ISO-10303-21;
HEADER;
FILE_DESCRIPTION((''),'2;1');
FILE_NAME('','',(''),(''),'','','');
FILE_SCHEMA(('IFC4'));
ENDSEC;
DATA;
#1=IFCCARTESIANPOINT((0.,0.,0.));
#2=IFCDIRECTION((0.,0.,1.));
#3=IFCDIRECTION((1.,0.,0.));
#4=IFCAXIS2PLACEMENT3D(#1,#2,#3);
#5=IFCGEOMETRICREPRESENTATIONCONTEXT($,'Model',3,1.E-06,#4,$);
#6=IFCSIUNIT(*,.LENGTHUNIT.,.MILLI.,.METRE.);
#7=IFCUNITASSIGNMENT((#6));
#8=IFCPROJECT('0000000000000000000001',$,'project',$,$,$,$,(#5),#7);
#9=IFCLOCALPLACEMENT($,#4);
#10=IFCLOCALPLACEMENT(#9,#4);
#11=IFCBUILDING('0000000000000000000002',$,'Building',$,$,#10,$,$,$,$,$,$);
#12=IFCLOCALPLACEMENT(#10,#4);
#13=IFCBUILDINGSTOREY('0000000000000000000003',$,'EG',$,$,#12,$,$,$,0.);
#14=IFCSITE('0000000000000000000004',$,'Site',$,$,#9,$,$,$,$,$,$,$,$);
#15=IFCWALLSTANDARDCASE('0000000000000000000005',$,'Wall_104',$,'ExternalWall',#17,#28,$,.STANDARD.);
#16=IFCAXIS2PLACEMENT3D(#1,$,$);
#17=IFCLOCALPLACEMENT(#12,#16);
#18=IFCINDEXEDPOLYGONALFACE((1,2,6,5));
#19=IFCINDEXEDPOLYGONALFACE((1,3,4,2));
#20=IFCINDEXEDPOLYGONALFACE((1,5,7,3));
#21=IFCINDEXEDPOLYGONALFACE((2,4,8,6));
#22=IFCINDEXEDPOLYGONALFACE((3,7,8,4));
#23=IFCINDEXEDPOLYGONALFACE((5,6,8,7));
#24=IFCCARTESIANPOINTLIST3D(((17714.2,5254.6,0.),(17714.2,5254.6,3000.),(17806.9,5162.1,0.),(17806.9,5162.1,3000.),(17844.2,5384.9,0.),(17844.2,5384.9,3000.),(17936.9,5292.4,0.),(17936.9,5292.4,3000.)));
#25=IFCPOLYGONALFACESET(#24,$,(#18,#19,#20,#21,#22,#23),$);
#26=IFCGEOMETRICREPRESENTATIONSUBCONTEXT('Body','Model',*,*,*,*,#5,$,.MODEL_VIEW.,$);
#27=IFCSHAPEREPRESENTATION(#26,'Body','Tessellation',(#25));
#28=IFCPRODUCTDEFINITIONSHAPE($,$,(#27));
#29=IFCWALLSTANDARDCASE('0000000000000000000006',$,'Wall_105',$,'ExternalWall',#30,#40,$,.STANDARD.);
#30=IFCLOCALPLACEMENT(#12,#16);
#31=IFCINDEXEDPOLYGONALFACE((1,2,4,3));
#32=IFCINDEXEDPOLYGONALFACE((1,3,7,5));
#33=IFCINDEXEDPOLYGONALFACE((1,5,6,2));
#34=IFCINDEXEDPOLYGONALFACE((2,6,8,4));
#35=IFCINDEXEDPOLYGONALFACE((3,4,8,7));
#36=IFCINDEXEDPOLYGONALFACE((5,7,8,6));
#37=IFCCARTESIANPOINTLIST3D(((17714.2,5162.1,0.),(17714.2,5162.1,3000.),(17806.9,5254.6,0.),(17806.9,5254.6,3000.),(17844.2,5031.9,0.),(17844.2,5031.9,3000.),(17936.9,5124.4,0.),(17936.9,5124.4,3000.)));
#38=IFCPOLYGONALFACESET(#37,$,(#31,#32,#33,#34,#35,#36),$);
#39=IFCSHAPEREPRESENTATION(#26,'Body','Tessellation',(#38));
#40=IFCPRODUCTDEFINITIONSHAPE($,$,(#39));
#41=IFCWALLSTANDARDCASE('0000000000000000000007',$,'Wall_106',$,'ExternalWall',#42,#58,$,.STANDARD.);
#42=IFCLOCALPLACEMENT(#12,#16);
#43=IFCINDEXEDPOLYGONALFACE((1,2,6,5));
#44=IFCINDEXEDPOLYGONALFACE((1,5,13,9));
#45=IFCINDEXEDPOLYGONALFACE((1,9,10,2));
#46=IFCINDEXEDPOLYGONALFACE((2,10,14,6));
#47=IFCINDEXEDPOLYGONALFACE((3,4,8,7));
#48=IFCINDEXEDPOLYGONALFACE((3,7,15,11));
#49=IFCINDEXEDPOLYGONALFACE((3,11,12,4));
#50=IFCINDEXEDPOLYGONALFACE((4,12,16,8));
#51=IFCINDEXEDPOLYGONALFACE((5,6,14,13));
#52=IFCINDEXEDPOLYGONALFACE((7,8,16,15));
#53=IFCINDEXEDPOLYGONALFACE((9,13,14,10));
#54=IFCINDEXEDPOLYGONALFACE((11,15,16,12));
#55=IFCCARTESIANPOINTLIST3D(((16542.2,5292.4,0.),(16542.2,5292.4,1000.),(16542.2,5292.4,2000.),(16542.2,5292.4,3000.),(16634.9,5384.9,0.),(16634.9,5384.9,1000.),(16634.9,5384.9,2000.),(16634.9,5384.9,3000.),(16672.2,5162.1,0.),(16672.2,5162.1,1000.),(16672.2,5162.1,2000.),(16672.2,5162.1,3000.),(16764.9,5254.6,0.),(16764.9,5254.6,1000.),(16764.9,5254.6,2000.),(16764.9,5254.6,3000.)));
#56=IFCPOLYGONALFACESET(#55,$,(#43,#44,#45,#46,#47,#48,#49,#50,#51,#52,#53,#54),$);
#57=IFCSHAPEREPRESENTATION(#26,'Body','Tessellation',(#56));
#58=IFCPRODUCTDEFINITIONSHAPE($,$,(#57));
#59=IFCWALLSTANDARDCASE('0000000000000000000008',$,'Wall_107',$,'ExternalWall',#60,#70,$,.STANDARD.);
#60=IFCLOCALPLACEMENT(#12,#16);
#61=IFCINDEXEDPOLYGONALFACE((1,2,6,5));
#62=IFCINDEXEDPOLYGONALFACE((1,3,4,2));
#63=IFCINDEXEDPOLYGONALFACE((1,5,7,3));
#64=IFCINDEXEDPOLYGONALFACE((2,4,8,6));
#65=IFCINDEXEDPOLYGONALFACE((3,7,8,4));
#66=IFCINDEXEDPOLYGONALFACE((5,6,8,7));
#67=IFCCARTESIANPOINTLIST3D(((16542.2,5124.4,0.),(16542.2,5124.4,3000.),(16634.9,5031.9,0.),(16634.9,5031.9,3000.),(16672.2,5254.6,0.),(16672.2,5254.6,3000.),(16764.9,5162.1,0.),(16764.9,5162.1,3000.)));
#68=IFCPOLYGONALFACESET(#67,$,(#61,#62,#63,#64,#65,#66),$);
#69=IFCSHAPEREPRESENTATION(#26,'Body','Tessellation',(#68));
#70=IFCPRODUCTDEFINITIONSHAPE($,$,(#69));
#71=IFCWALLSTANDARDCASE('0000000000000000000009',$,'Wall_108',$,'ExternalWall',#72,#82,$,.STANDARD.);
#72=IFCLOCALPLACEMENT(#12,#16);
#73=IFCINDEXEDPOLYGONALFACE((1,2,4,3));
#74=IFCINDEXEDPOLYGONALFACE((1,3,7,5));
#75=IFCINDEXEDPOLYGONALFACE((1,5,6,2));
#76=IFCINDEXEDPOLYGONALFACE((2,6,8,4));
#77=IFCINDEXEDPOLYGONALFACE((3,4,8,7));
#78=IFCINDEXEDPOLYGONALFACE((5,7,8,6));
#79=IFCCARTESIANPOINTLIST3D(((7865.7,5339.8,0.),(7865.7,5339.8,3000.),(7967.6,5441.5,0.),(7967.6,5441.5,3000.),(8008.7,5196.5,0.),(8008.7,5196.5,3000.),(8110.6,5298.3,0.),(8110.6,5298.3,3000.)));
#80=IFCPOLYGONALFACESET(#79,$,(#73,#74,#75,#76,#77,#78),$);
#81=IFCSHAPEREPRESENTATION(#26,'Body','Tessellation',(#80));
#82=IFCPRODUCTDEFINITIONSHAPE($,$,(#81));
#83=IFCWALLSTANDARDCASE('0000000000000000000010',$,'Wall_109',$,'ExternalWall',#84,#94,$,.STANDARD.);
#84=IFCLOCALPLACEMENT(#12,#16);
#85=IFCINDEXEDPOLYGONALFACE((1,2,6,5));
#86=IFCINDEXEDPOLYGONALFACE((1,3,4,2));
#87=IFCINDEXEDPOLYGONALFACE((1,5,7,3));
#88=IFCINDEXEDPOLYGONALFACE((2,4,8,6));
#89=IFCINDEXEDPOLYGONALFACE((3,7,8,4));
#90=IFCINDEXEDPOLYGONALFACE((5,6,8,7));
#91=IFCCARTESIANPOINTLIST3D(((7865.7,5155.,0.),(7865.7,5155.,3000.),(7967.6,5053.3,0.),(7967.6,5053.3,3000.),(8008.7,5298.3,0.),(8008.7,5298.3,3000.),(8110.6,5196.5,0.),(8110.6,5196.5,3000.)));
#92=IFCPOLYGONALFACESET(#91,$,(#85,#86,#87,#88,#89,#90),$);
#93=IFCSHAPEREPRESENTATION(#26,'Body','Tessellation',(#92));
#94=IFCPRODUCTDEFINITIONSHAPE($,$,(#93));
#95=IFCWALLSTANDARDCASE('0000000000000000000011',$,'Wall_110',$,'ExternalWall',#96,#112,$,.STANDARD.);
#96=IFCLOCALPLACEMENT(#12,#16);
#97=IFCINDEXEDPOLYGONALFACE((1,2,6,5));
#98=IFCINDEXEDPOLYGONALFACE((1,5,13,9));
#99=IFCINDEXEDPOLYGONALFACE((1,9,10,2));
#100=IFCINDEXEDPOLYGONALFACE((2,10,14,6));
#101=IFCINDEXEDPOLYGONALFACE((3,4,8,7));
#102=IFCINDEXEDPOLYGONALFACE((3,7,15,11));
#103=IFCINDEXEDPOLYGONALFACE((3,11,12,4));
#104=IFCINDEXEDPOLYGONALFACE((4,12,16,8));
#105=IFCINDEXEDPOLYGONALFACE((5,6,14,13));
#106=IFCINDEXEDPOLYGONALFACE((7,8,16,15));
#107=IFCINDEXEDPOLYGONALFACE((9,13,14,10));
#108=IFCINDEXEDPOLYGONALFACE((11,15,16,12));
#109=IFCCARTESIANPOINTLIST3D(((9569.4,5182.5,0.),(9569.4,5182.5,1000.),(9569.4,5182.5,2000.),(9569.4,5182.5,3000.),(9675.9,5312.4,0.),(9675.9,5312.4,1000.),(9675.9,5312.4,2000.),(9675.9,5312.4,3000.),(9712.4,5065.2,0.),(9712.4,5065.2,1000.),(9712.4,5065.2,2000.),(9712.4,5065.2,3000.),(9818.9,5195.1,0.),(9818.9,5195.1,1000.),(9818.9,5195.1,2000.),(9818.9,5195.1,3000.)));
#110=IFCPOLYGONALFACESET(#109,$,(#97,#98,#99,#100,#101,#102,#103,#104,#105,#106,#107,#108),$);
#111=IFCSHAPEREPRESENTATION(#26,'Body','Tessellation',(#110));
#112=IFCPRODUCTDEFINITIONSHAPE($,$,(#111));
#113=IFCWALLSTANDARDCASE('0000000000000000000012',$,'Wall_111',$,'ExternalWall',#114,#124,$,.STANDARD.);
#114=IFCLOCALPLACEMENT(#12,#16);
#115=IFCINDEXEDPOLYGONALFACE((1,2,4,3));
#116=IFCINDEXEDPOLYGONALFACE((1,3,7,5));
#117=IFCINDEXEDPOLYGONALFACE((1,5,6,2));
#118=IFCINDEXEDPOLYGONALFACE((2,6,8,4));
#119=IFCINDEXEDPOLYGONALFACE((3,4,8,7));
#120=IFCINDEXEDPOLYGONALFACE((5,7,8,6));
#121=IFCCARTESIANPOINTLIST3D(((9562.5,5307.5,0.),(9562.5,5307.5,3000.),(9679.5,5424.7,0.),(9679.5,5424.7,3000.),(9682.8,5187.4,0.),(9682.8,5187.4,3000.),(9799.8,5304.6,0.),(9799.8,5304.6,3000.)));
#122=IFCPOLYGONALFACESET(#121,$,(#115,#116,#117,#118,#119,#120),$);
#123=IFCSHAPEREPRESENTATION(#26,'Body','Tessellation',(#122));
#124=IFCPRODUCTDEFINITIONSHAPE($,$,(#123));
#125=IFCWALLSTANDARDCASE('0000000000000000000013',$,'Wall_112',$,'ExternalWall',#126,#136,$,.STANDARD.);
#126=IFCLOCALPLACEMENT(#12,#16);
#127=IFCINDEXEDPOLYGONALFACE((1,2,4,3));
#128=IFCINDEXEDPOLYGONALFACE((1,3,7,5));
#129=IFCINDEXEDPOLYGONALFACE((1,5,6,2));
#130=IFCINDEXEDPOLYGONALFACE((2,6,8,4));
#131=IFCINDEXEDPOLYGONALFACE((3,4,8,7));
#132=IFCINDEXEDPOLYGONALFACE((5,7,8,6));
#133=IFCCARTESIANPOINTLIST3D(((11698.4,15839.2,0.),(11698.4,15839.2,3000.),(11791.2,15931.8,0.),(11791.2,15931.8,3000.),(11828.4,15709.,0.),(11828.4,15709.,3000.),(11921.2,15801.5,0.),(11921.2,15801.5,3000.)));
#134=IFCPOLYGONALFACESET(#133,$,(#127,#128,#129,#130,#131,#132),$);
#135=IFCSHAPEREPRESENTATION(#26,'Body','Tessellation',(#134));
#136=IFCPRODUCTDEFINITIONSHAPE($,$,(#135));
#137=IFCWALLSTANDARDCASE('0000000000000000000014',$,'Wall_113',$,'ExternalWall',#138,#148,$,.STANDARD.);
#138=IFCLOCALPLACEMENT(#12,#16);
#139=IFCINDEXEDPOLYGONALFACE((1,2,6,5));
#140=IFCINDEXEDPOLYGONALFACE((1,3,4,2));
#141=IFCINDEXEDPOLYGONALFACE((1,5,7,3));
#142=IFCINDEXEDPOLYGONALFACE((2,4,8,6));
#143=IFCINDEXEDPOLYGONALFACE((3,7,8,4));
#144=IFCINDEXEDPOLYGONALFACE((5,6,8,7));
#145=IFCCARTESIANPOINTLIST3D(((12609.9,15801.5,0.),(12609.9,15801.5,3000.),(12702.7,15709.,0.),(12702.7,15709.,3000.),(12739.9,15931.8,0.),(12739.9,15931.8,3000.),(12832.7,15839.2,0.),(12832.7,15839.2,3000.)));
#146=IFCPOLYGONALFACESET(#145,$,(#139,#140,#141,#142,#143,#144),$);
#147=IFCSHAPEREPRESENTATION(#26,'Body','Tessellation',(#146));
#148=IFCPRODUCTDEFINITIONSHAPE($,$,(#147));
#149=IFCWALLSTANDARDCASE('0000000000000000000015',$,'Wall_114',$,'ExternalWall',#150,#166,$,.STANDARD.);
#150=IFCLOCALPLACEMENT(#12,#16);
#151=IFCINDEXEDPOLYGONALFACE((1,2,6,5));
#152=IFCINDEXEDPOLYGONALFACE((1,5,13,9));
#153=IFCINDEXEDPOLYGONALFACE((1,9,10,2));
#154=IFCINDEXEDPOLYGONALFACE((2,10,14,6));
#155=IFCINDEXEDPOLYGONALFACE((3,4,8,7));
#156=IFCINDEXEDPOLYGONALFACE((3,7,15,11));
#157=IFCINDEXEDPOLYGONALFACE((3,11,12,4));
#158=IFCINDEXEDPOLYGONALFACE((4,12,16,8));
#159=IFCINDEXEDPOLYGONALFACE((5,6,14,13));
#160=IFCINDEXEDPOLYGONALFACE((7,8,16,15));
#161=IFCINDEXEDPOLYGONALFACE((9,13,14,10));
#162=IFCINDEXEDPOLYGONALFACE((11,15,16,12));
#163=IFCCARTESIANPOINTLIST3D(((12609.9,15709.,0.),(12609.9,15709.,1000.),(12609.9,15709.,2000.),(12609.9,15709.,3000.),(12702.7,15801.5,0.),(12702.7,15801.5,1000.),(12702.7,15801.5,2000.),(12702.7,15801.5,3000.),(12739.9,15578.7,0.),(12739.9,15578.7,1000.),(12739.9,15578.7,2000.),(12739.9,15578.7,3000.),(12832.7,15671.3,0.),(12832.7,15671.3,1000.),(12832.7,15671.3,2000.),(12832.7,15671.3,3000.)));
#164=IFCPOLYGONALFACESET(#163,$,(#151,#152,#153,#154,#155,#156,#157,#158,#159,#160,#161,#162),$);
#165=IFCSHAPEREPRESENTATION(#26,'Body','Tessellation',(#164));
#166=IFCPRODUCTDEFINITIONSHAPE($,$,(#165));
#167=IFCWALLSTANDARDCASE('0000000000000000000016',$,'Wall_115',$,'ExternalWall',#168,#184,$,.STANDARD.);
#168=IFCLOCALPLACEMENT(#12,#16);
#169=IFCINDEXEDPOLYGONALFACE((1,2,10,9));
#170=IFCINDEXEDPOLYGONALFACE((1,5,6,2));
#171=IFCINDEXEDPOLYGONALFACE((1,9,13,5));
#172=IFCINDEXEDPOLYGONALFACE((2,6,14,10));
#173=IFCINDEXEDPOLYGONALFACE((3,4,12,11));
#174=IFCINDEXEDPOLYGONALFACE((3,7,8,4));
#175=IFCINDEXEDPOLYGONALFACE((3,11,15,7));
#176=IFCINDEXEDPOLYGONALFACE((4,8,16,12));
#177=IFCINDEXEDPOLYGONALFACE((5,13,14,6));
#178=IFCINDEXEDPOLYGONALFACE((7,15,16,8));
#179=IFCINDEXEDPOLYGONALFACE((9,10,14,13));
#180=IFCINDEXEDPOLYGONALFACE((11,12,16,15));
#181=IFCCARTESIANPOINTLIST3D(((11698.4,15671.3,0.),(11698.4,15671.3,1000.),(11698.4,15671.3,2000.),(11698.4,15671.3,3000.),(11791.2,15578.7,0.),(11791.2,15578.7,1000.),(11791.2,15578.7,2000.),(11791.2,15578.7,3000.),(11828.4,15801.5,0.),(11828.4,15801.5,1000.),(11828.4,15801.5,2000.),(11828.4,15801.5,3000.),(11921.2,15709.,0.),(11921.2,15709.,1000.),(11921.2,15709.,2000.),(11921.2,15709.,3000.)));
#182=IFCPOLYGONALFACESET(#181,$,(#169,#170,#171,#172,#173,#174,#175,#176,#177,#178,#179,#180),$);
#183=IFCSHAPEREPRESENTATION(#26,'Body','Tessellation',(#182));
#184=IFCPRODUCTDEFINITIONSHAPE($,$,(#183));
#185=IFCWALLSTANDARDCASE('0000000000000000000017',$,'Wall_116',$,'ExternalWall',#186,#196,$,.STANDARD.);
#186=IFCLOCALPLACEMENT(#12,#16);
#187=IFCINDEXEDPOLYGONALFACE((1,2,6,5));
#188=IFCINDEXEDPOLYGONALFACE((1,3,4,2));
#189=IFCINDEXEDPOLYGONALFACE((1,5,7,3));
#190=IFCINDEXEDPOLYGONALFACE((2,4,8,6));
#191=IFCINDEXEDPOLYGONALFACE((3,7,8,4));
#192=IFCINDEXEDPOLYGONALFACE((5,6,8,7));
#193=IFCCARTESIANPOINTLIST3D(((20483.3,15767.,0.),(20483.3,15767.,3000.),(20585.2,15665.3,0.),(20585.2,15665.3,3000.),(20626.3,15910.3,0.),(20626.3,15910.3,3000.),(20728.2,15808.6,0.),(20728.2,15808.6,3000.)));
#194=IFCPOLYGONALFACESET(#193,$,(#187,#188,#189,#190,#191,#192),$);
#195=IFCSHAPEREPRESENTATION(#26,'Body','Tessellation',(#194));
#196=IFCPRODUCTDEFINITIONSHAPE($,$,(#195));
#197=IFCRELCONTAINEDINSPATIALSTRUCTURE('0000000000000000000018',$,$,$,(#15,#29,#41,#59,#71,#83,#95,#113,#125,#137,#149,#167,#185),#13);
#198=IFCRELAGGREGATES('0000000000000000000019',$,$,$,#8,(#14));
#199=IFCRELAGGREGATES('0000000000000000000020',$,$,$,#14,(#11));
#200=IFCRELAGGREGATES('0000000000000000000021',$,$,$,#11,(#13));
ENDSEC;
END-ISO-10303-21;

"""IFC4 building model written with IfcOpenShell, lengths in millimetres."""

from ifc_helpers import new_model, si_unit, frame, origin_with_axes, place, context, subcontext, project, spatial, rectangle, extrude, element, save


model = new_model("IFC4")

# Units and contexts
model_context = context("Model", 3, precision=1e-06, world=origin_with_axes())
body_context = subcontext(model_context, "Body", "Model", "MODEL_VIEW")
ifc_project = project(units=[si_unit("LENGTHUNIT", "METRE", prefix="MILLI")], contexts=[model_context])

# Site, building, storey
site_placement = place(None, origin_with_axes())
site = spatial("IfcSite", under=ifc_project, at=site_placement, Name="Site")
building_placement = place(site_placement, origin_with_axes())
building = spatial("IfcBuilding", under=site, at=building_placement, Name="Building")
storey_placement = place(building_placement, origin_with_axes())
storey = spatial("IfcBuildingStorey", under=building, at=storey_placement, Name="EG", Elevation=0.0)

# Walls
wall_1_placement = place(storey_placement, origin_with_axes())
element("IfcWallStandardCase", 1, at=wall_1_placement, inside=storey, Name="Wall_104", ObjectType="ExternalWall", PredefinedType="STANDARD", context=body_context, shape_type="SweptSolid", body=[
    extrude(rectangle(XDim=184.0, YDim=131.0), frame((17825.5, 5273.5, 0.0), z_axis=(0.0, 0.0, 1.0), x_axis=(0.706427, 0.707786, 0.0)), (0.0, 0.0, 1.0), 3000.0),
])
wall_2_placement = place(storey_placement, origin_with_axes())
element("IfcWallStandardCase", 2, at=wall_2_placement, inside=storey, Name="Wall_105", ObjectType="ExternalWall", PredefinedType="STANDARD", context=body_context, shape_type="SweptSolid", body=[
    extrude(rectangle(XDim=184.0, YDim=131.0), frame((17825.5, 5143.3, 0.0), z_axis=(0.0, 0.0, 1.0), x_axis=(0.706427, -0.707786, 0.0)), (0.0, 0.0, 1.0), 3000.0),
])

# Wall, opening
wall_3_placement = place(storey_placement, origin_with_axes())
wall_3 = element("IfcWallStandardCase", 3, at=wall_3_placement, inside=storey, Name="Wall_106", ObjectType="ExternalWall", PredefinedType="STANDARD", context=body_context, shape_type="SweptSolid", body=[
    extrude(rectangle(XDim=184.0, YDim=131.0), frame((16653.5, 5273.5, 0.0), z_axis=(0.0, 0.0, 1.0), x_axis=(-0.706427, 0.707786, 0.0)), (0.0, 0.0, 1.0), 3000.0),
])
opening_1_placement = place(wall_3_placement, origin_with_axes())
element("IfcOpeningElement", 4, at=opening_1_placement, inside=storey, cuts=wall_3, context=body_context, shape_type="SweptSolid", body=[
    extrude(rectangle(XDim=600.0, YDim=131.0), frame((16647.2, 5279.9, 1000.0), z_axis=(0.0, 0.0, 1.0), x_axis=(-0.706427, 0.707786, 0.0)), (0.0, 0.0, 1.0), 1000.0),
])

# Walls
wall_4_placement = place(storey_placement, origin_with_axes())
element("IfcWallStandardCase", 5, at=wall_4_placement, inside=storey, Name="Wall_107", ObjectType="ExternalWall", PredefinedType="STANDARD", context=body_context, shape_type="SweptSolid", body=[
    extrude(rectangle(XDim=184.0, YDim=131.0), frame((16653.5, 5143.3, 0.0), z_axis=(0.0, 0.0, 1.0), x_axis=(-0.706427, -0.707786, 0.0)), (0.0, 0.0, 1.0), 3000.0),
])
wall_5_placement = place(storey_placement, origin_with_axes())
element("IfcWallStandardCase", 6, at=wall_5_placement, inside=storey, Name="Wall_108", ObjectType="ExternalWall", PredefinedType="STANDARD", context=body_context, shape_type="SweptSolid", body=[
    extrude(rectangle(XDim=202.4, YDim=144.0), frame((7988.2, 5319.0, 0.0), z_axis=(0.0, 0.0, 1.0), x_axis=(-0.706489, 0.707724, 0.0)), (0.0, 0.0, 1.0), 3000.0),
])
wall_6_placement = place(storey_placement, origin_with_axes())
element("IfcWallStandardCase", 7, at=wall_6_placement, inside=storey, Name="Wall_109", ObjectType="ExternalWall", PredefinedType="STANDARD", context=body_context, shape_type="SweptSolid", body=[
    extrude(rectangle(XDim=202.4, YDim=144.0), frame((7988.2, 5175.8, 0.0), z_axis=(0.0, 0.0, 1.0), x_axis=(-0.706489, -0.707724, 0.0)), (0.0, 0.0, 1.0), 3000.0),
])

# Wall, opening
wall_7_placement = place(storey_placement, origin_with_axes())
wall_7 = element("IfcWallStandardCase", 8, at=wall_7_placement, inside=storey, Name="Wall_110", ObjectType="ExternalWall", PredefinedType="STANDARD", context=body_context, shape_type="SweptSolid", body=[
    extrude(rectangle(XDim=184.9, YDim=168.0), frame((9694.2, 5188.8, 0.0), z_axis=(0.0, 0.0, 1.0), x_axis=(0.773294, -0.634047, 0.0)), (0.0, 0.0, 1.0), 3000.0),
])
opening_2_placement = place(wall_7_placement, origin_with_axes())
element("IfcOpeningElement", 9, at=opening_2_placement, inside=storey, cuts=wall_7, context=body_context, shape_type="SweptSolid", body=[
    extrude(rectangle(XDim=600.0, YDim=168.0), frame((9717.4, 5169.8, 1000.0), z_axis=(0.0, 0.0, 1.0), x_axis=(0.773294, -0.634047, 0.0)), (0.0, 0.0, 1.0), 1000.0),
])

# Walls
wall_8_placement = place(storey_placement, origin_with_axes())
element("IfcWallStandardCase", 10, at=wall_8_placement, inside=storey, Name="Wall_111", ObjectType="ExternalWall", PredefinedType="STANDARD", context=body_context, shape_type="SweptSolid", body=[
    extrude(rectangle(XDim=165.6, YDim=170.0), frame((9681.2, 5306.0, 0.0), z_axis=(0.0, 0.0, 1.0), x_axis=(0.706352, 0.707861, 0.0)), (0.0, 0.0, 1.0), 3000.0),
])
wall_9_placement = place(storey_placement, origin_with_axes())
element("IfcWallStandardCase", 11, at=wall_9_placement, inside=storey, Name="Wall_112", ObjectType="ExternalWall", PredefinedType="STANDARD", context=body_context, shape_type="SweptSolid", body=[
    extrude(rectangle(XDim=184.0, YDim=131.0), frame((11809.8, 15820.4, 0.0), z_axis=(0.0, 0.0, 1.0), x_axis=(0.706427, -0.707786, 0.0)), (0.0, 0.0, 1.0), 3000.0),
])
wall_10_placement = place(storey_placement, origin_with_axes())
element("IfcWallStandardCase", 12, at=wall_10_placement, inside=storey, Name="Wall_113", ObjectType="ExternalWall", PredefinedType="STANDARD", context=body_context, shape_type="SweptSolid", body=[
    extrude(rectangle(XDim=184.0, YDim=131.0), frame((12721.3, 15820.4, 0.0), z_axis=(0.0, 0.0, 1.0), x_axis=(0.706427, 0.707786, 0.0)), (0.0, 0.0, 1.0), 3000.0),
])

# Walls, openings
wall_11_placement = place(storey_placement, origin_with_axes())
wall_11 = element("IfcWallStandardCase", 13, at=wall_11_placement, inside=storey, Name="Wall_114", ObjectType="ExternalWall", PredefinedType="STANDARD", context=body_context, shape_type="SweptSolid", body=[
    extrude(rectangle(XDim=184.0, YDim=131.0), frame((12721.3, 15690.1, 0.0), z_axis=(0.0, 0.0, 1.0), x_axis=(0.706427, -0.707786, 0.0)), (0.0, 0.0, 1.0), 3000.0),
])
opening_3_placement = place(wall_11_placement, origin_with_axes())
element("IfcOpeningElement", 14, at=opening_3_placement, inside=storey, cuts=wall_11, context=body_context, shape_type="SweptSolid", body=[
    extrude(rectangle(XDim=600.0, YDim=131.0), frame((12721.3, 15690.1, 1000.0), z_axis=(0.0, 0.0, 1.0), x_axis=(0.706427, -0.707786, 0.0)), (0.0, 0.0, 1.0), 1000.0),
])
wall_12_placement = place(storey_placement, origin_with_axes())
wall_12 = element("IfcWallStandardCase", 15, at=wall_12_placement, inside=storey, Name="Wall_115", ObjectType="ExternalWall", PredefinedType="STANDARD", context=body_context, shape_type="SweptSolid", body=[
    extrude(rectangle(XDim=184.0, YDim=131.0), frame((11809.8, 15690.1, 0.0), z_axis=(0.0, 0.0, 1.0), x_axis=(-0.706427, -0.707786, 0.0)), (0.0, 0.0, 1.0), 3000.0),
])
opening_4_placement = place(wall_12_placement, origin_with_axes())
element("IfcOpeningElement", 16, at=opening_4_placement, inside=storey, cuts=wall_12, context=body_context, shape_type="SweptSolid", body=[
    extrude(rectangle(XDim=600.0, YDim=131.0), frame((11790.4, 15670.7, 1000.0), z_axis=(0.0, 0.0, 1.0), x_axis=(-0.706427, -0.707786, 0.0)), (0.0, 0.0, 1.0), 1000.0),
])

# Wall
wall_13_placement = place(storey_placement, origin_with_axes())
element("IfcWallStandardCase", 17, at=wall_13_placement, inside=storey, Name="Wall_116", ObjectType="ExternalWall", PredefinedType="STANDARD", context=body_context, shape_type="SweptSolid", body=[
    extrude(rectangle(XDim=202.4, YDim=144.0), frame((20605.8, 15787.8, 0.0), z_axis=(0.0, 0.0, 1.0), x_axis=(0.706489, 0.707724, 0.0)), (0.0, 0.0, 1.0), 3000.0),
])

save(model, "model.ifc")
